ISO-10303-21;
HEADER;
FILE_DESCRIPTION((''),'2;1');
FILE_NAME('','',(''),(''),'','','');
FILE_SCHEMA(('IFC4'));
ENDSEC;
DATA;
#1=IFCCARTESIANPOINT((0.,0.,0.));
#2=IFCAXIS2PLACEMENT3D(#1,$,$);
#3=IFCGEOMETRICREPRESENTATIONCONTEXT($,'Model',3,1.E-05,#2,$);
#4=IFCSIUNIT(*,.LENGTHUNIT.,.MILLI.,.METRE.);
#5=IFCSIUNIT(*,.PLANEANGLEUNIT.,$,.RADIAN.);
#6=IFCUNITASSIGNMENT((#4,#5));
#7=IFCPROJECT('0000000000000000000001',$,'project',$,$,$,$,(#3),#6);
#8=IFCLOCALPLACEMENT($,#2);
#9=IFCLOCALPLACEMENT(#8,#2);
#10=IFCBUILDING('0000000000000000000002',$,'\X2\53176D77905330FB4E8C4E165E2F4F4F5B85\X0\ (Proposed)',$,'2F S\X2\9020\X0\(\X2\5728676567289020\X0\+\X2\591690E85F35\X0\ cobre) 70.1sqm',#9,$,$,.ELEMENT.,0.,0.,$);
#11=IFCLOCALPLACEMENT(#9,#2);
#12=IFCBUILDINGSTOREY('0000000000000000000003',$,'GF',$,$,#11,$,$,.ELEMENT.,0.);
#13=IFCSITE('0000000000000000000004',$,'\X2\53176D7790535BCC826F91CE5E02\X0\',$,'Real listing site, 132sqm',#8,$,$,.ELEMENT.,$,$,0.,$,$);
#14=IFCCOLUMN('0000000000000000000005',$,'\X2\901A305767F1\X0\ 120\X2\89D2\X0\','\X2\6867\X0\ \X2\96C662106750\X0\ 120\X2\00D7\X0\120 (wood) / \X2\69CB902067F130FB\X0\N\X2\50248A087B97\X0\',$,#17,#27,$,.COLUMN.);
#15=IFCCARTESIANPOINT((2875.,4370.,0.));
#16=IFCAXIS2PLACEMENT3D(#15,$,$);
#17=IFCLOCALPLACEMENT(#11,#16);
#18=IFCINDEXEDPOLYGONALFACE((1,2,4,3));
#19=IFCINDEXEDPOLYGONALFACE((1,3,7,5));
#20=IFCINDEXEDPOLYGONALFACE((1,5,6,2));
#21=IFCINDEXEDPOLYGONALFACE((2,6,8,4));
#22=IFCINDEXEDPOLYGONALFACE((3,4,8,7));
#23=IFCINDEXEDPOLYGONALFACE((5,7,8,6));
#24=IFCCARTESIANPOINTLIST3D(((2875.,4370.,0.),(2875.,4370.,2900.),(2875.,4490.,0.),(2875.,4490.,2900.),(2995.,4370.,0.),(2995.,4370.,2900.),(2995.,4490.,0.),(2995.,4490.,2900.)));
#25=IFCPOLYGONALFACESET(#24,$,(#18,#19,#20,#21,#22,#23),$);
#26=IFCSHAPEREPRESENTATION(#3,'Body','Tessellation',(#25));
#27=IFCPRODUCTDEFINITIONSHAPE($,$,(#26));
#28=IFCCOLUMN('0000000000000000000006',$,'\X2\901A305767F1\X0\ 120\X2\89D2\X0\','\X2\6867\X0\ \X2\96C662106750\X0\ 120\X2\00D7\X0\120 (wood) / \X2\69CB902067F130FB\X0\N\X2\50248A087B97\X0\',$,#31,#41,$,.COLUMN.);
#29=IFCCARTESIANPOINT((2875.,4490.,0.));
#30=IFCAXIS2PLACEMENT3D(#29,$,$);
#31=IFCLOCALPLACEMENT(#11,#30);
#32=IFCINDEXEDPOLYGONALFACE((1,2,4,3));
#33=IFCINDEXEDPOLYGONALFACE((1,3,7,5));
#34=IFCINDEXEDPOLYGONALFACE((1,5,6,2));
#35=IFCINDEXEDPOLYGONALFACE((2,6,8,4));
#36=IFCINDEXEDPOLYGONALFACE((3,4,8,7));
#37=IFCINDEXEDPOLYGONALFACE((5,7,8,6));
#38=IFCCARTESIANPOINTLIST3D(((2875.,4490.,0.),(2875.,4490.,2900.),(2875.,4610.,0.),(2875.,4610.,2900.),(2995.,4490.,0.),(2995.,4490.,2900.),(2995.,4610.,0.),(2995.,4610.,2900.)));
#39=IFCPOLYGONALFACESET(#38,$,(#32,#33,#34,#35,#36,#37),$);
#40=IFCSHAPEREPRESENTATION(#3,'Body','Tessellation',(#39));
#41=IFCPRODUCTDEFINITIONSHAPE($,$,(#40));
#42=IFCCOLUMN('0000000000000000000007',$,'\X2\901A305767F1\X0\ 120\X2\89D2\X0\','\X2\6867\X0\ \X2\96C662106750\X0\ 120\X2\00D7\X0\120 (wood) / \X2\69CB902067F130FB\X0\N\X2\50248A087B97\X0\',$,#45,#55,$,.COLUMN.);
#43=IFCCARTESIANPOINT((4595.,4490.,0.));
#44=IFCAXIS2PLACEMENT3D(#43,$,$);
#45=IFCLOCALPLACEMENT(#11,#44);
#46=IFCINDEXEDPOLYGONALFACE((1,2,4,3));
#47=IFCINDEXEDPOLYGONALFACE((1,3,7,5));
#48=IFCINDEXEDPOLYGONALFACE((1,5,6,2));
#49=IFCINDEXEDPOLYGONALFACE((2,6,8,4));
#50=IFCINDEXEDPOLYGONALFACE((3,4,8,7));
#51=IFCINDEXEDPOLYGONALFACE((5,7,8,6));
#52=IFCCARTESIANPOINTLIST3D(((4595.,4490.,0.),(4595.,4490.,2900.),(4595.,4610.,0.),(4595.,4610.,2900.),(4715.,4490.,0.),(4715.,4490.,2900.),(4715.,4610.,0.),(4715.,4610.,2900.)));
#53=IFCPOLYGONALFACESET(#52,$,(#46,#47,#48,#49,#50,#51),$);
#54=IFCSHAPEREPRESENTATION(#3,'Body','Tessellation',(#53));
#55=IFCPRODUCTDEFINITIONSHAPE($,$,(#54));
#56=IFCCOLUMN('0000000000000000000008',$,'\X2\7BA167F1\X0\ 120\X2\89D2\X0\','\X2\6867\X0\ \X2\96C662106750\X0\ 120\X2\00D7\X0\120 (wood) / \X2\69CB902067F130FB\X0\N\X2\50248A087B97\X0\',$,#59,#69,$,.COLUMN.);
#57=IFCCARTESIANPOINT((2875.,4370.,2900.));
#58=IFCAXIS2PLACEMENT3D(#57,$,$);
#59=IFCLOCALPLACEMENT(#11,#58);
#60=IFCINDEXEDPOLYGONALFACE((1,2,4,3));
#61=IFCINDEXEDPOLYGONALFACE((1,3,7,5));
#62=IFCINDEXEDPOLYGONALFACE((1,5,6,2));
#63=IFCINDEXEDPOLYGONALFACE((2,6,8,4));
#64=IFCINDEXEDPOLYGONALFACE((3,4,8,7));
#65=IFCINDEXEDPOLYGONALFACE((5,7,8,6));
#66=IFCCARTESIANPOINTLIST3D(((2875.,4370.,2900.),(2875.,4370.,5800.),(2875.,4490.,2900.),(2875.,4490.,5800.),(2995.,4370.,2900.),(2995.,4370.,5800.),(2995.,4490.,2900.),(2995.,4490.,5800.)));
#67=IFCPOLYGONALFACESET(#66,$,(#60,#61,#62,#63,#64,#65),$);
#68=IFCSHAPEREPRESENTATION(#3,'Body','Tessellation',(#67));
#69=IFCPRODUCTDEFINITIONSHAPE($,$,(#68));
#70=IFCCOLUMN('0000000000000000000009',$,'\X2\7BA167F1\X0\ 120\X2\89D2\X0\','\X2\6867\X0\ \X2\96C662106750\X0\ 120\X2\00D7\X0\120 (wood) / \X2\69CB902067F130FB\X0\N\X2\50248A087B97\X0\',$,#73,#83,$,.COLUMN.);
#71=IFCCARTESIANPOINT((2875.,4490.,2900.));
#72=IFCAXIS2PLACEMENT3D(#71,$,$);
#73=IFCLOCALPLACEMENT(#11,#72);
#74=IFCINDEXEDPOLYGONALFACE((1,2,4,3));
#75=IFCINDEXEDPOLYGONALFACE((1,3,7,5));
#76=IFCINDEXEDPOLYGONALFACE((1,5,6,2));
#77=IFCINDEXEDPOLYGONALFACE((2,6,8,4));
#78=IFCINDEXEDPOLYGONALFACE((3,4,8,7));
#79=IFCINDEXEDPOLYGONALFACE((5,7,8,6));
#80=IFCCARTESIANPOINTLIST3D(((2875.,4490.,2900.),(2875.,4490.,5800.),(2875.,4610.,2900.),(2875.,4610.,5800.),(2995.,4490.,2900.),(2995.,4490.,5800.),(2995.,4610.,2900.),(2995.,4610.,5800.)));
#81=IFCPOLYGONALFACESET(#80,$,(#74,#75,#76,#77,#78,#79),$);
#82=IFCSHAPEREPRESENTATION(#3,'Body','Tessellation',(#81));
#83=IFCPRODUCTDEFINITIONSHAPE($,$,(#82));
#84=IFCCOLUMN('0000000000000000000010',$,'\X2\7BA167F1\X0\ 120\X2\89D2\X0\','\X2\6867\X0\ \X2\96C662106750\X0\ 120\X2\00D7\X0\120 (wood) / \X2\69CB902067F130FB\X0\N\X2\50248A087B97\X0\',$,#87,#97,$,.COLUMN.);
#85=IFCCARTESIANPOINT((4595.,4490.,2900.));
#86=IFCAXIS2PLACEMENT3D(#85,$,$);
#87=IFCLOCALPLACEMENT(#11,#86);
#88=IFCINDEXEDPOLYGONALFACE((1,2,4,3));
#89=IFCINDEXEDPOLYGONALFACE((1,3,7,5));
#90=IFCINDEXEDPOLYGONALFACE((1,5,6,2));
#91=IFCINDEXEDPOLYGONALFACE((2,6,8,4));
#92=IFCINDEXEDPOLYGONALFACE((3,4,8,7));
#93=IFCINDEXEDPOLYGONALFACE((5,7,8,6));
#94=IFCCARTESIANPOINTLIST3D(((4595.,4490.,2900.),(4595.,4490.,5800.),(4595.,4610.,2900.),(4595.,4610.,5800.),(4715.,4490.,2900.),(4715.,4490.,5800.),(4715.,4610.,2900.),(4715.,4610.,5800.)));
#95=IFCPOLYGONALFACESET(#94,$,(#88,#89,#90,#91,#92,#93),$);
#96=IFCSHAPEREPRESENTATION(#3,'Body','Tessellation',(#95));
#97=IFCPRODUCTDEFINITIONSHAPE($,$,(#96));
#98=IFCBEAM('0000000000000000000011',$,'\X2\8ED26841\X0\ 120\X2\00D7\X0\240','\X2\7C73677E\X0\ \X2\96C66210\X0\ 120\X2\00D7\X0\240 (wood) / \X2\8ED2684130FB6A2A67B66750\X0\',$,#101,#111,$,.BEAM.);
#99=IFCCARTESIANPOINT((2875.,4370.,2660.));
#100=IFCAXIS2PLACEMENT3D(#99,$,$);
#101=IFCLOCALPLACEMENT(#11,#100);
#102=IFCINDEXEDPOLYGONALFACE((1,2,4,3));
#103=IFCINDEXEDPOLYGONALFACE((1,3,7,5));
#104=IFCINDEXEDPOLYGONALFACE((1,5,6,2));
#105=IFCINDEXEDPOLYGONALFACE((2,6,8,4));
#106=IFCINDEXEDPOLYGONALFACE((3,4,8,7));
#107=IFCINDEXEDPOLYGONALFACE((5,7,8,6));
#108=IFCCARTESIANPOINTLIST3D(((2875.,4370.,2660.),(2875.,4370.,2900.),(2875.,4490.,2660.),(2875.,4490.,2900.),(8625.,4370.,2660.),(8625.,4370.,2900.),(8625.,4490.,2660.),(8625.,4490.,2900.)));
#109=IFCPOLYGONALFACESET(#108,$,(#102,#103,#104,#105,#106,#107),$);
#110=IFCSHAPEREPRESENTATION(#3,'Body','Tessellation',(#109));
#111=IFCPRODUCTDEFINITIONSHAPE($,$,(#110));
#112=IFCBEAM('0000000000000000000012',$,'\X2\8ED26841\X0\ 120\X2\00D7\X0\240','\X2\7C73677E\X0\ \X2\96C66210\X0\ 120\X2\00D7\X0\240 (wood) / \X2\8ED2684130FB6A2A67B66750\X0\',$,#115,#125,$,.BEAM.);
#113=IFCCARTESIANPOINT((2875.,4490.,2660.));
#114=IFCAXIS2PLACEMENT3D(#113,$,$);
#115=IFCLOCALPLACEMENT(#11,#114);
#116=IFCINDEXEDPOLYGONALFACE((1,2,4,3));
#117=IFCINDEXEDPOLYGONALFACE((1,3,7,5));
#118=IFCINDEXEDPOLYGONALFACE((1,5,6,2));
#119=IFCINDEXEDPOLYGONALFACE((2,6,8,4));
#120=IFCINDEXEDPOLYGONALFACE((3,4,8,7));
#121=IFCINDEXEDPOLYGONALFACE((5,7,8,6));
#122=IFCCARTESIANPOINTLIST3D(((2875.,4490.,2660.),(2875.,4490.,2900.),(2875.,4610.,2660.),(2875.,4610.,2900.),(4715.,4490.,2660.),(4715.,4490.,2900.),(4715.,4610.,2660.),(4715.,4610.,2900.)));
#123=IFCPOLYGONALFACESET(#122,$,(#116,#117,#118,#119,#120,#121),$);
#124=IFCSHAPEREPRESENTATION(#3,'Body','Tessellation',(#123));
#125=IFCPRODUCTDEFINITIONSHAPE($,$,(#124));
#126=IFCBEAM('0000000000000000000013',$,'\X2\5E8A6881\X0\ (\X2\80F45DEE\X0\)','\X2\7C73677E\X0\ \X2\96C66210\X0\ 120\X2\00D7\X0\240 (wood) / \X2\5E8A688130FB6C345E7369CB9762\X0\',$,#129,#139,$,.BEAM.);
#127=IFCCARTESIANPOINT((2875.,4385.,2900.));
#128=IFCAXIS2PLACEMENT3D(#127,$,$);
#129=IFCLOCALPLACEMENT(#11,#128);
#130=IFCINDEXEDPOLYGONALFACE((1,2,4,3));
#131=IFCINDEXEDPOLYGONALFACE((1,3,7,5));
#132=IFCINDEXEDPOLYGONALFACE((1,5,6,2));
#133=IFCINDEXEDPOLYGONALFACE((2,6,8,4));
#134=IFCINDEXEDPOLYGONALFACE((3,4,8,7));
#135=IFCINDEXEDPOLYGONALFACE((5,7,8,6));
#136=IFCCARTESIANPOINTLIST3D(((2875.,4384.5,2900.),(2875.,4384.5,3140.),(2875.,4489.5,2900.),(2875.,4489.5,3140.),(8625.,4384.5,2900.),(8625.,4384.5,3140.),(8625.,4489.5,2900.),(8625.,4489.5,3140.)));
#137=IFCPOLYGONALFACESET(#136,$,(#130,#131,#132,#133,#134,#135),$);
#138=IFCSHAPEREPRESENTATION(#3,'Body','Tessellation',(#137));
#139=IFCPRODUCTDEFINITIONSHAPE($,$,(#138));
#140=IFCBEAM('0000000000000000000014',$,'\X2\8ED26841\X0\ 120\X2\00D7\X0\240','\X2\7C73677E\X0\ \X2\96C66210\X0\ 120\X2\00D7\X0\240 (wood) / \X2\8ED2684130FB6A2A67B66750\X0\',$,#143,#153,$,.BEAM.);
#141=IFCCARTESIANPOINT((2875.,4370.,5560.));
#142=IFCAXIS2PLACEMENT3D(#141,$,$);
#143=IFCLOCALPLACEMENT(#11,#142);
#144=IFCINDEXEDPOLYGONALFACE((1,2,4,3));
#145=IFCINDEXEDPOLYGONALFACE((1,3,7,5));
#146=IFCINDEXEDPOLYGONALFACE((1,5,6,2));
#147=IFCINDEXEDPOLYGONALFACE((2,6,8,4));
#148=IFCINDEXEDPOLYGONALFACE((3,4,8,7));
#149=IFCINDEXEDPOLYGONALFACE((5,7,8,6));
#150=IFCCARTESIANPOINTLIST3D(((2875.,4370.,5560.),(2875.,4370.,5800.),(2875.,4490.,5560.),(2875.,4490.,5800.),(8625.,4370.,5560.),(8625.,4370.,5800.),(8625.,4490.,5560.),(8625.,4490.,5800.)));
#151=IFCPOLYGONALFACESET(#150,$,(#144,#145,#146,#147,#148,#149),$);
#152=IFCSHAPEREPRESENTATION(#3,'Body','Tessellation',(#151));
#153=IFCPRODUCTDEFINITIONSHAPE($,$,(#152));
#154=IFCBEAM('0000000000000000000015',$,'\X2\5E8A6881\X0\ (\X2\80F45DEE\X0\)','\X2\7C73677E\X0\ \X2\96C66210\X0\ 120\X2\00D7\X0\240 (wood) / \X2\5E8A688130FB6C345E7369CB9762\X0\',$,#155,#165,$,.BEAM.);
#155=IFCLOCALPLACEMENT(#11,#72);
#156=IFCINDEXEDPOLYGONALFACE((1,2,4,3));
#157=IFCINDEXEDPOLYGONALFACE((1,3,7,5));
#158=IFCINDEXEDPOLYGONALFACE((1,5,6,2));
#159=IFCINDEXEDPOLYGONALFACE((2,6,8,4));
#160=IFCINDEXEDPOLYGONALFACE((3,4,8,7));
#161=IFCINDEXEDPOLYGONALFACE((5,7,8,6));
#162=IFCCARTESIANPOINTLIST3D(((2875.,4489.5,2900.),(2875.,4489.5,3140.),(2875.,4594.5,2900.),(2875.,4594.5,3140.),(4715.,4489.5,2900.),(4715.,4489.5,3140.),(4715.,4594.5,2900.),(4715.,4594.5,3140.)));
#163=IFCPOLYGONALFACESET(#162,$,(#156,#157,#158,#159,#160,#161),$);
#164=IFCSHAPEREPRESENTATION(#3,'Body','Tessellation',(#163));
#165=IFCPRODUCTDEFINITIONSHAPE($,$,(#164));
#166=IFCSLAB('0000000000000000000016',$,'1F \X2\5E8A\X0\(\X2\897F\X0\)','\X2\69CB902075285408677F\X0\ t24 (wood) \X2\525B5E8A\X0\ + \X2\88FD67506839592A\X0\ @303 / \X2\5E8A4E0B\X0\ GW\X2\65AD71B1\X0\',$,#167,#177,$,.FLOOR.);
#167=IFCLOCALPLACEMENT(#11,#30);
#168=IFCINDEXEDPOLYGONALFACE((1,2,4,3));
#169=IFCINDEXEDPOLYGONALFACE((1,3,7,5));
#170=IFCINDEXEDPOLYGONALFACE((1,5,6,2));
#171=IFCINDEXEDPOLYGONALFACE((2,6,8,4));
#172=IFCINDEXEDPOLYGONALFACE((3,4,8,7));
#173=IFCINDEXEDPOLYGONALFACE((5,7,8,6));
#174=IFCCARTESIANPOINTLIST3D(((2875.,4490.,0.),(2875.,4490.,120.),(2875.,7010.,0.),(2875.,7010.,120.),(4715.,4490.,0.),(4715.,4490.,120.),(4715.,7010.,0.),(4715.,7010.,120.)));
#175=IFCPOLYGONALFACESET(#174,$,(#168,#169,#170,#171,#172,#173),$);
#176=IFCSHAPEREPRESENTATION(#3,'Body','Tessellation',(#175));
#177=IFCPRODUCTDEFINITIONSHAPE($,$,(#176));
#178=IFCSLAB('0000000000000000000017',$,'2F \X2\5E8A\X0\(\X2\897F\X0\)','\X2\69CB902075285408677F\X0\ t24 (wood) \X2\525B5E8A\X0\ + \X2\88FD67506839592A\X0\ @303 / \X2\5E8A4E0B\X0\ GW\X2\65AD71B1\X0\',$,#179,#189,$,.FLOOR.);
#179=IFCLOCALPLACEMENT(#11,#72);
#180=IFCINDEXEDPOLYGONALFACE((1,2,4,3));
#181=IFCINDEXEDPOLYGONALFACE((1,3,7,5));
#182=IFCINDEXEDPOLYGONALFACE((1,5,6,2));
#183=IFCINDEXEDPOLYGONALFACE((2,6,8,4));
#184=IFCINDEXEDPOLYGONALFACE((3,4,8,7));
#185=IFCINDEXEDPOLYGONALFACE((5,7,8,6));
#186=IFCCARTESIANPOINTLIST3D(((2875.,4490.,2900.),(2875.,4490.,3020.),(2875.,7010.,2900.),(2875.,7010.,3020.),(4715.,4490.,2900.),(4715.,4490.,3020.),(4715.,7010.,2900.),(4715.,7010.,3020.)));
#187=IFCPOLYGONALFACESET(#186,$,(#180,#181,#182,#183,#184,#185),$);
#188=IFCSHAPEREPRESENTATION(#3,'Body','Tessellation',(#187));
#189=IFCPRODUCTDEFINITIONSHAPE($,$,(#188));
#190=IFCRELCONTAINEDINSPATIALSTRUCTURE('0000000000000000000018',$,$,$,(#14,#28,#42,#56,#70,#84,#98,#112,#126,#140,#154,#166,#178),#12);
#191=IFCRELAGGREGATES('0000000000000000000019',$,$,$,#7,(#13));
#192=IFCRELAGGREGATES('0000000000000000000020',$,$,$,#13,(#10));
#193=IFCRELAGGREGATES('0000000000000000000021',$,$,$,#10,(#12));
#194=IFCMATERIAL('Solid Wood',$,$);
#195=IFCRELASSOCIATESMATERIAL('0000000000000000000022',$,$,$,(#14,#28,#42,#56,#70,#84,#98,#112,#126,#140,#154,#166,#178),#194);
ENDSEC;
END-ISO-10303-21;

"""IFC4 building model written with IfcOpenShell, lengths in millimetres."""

from ifc_helpers import new_model, si_unit, frame, frame_2d, origin, place, context, project, spatial, rectangle, extrude, material, element, save


model = new_model("IFC4")

# Units and contexts
model_context = context("Model", 3, precision=1e-05, world=origin())
ifc_project = project(units=[si_unit("LENGTHUNIT", "METRE", prefix="MILLI"), si_unit("PLANEANGLEUNIT", "RADIAN")], contexts=[model_context])

# Site, building, storey
site_placement = place(None, origin())
site = spatial("IfcSite", under=ifc_project, at=site_placement, Name="北海道富良野市", ObjectType="Real listing site, 132sqm", CompositionType="ELEMENT", RefElevation=0.0)
building_placement = place(site_placement, origin())
building = spatial("IfcBuilding", under=site, at=building_placement, Name="北海道・二世帯住宅 (Proposed)", ObjectType="2F S造(在来木造+外部張 cobre) 70.1sqm", CompositionType="ELEMENT", ElevationOfRefHeight=0.0, ElevationOfTerrain=0.0)
storey_placement = place(building_placement, origin())
storey = spatial("IfcBuildingStorey", under=building, at=storey_placement, Name="GF", CompositionType="ELEMENT", Elevation=0.0)

# Columns
ifc_material_1 = material(Name="Solid Wood")
column_1_placement = place(storey_placement, frame((2875.0, 4370.0, 0.0)))
element("IfcColumn", 1, at=column_1_placement, inside=storey, material=ifc_material_1, Name="通し柱 120角", Description="桧 集成材 120×120 (wood) / 構造柱・N値計算", PredefinedType="COLUMN", context=model_context, shape_type="SweptSolid", body=[
    extrude(rectangle(XDim=120.0, YDim=120.0, at=frame_2d((60.0, 60.0))), frame((2875.0, 4370.0, 0.0)), (0.0, 0.0, 1.0), 2900.0),
])
column_2_placement = place(storey_placement, frame((2875.0, 4490.0, 0.0)))
element("IfcColumn", 2, at=column_2_placement, inside=storey, material=ifc_material_1, Name="通し柱 120角", Description="桧 集成材 120×120 (wood) / 構造柱・N値計算", PredefinedType="COLUMN", context=model_context, shape_type="SweptSolid", body=[
    extrude(rectangle(XDim=120.0, YDim=120.0, at=frame_2d((60.0, 60.0))), frame((2875.0, 4490.0, 0.0)), (0.0, 0.0, 1.0), 2900.0),
])
column_3_placement = place(storey_placement, frame((4595.0, 4490.0, 0.0)))
element("IfcColumn", 3, at=column_3_placement, inside=storey, material=ifc_material_1, Name="通し柱 120角", Description="桧 集成材 120×120 (wood) / 構造柱・N値計算", PredefinedType="COLUMN", context=model_context, shape_type="SweptSolid", body=[
    extrude(rectangle(XDim=120.0, YDim=120.0, at=frame_2d((60.0, 60.0))), frame((4595.0, 4490.0, 0.0)), (0.0, 0.0, 1.0), 2900.0),
])
column_4_placement = place(storey_placement, frame((2875.0, 4370.0, 2900.0)))
element("IfcColumn", 4, at=column_4_placement, inside=storey, material=ifc_material_1, Name="管柱 120角", Description="桧 集成材 120×120 (wood) / 構造柱・N値計算", PredefinedType="COLUMN", context=model_context, shape_type="SweptSolid", body=[
    extrude(rectangle(XDim=120.0, YDim=120.0, at=frame_2d((60.0, 60.0))), frame((2875.0, 4370.0, 2900.0)), (0.0, 0.0, 1.0), 2900.0),
])
column_5_placement = place(storey_placement, frame((2875.0, 4490.0, 2900.0)))
element("IfcColumn", 5, at=column_5_placement, inside=storey, material=ifc_material_1, Name="管柱 120角", Description="桧 集成材 120×120 (wood) / 構造柱・N値計算", PredefinedType="COLUMN", context=model_context, shape_type="SweptSolid", body=[
    extrude(rectangle(XDim=120.0, YDim=120.0, at=frame_2d((60.0, 60.0))), frame((2875.0, 4490.0, 2900.0)), (0.0, 0.0, 1.0), 2900.0),
])
column_6_placement = place(storey_placement, frame((4595.0, 4490.0, 2900.0)))
element("IfcColumn", 6, at=column_6_placement, inside=storey, material=ifc_material_1, Name="管柱 120角", Description="桧 集成材 120×120 (wood) / 構造柱・N値計算", PredefinedType="COLUMN", context=model_context, shape_type="SweptSolid", body=[
    extrude(rectangle(XDim=120.0, YDim=120.0, at=frame_2d((60.0, 60.0))), frame((4595.0, 4490.0, 2900.0)), (0.0, 0.0, 1.0), 2900.0),
])

# Beams
beam_1_placement = place(storey_placement, frame((2875.0, 4370.0, 2660.0)))
element("IfcBeam", 7, at=beam_1_placement, inside=storey, material=ifc_material_1, Name="軒桁 120×240", Description="米松 集成 120×240 (wood) / 軒桁・横架材", PredefinedType="BEAM", context=model_context, shape_type="SweptSolid", body=[
    extrude(rectangle(XDim=5750.0, YDim=120.0, at=frame_2d((2875.0, 60.0))), frame((2875.0, 4370.0, 2660.0)), (0.0, 0.0, 1.0), 240.0),
])
beam_2_placement = place(storey_placement, frame((2875.0, 4490.0, 2660.0)))
element("IfcBeam", 8, at=beam_2_placement, inside=storey, material=ifc_material_1, Name="軒桁 120×240", Description="米松 集成 120×240 (wood) / 軒桁・横架材", PredefinedType="BEAM", context=model_context, shape_type="SweptSolid", body=[
    extrude(rectangle(XDim=1840.0, YDim=120.0, at=frame_2d((920.0, 60.0))), frame((2875.0, 4490.0, 2660.0)), (0.0, 0.0, 1.0), 240.0),
])
beam_3_placement = place(storey_placement, frame((2875.0, 4385.0, 2900.0)))
element("IfcBeam", 9, at=beam_3_placement, inside=storey, material=ifc_material_1, Name="床梁 (胴差)", Description="米松 集成 120×240 (wood) / 床梁・水平構面", PredefinedType="BEAM", context=model_context, shape_type="SweptSolid", body=[
    extrude(rectangle(XDim=5750.0, YDim=105.0, at=frame_2d((2875.0, 52.0))), frame((2875.0, 4385.0, 2900.0)), (0.0, 0.0, 1.0), 240.0),
])
beam_4_placement = place(storey_placement, frame((2875.0, 4370.0, 5560.0)))
element("IfcBeam", 10, at=beam_4_placement, inside=storey, material=ifc_material_1, Name="軒桁 120×240", Description="米松 集成 120×240 (wood) / 軒桁・横架材", PredefinedType="BEAM", context=model_context, shape_type="SweptSolid", body=[
    extrude(rectangle(XDim=5750.0, YDim=120.0, at=frame_2d((2875.0, 60.0))), frame((2875.0, 4370.0, 5560.0)), (0.0, 0.0, 1.0), 240.0),
])
beam_5_placement = place(storey_placement, frame((2875.0, 4490.0, 2900.0)))
element("IfcBeam", 11, at=beam_5_placement, inside=storey, material=ifc_material_1, Name="床梁 (胴差)", Description="米松 集成 120×240 (wood) / 床梁・水平構面", PredefinedType="BEAM", context=model_context, shape_type="SweptSolid", body=[
    extrude(rectangle(XDim=1840.0, YDim=105.0, at=frame_2d((920.0, 52.0))), frame((2875.0, 4490.0, 2900.0)), (0.0, 0.0, 1.0), 240.0),
])

# Slabs
slab_1_placement = place(storey_placement, frame((2875.0, 4490.0, 0.0)))
element("IfcSlab", 12, at=slab_1_placement, inside=storey, material=ifc_material_1, Name="1F 床(西)", Description="構造用合板 t24 (wood) 剛床 + 製材根太 @303 / 床下 GW断熱", PredefinedType="FLOOR", context=model_context, shape_type="SweptSolid", body=[
    extrude(rectangle(XDim=1840.0, YDim=2520.0, at=frame_2d((920.0, 1260.0))), frame((2875.0, 4490.0, 0.0)), (0.0, 0.0, 1.0), 120.0),
])
slab_2_placement = place(storey_placement, frame((2875.0, 4490.0, 2900.0)))
element("IfcSlab", 13, at=slab_2_placement, inside=storey, material=ifc_material_1, Name="2F 床(西)", Description="構造用合板 t24 (wood) 剛床 + 製材根太 @303 / 床下 GW断熱", PredefinedType="FLOOR", context=model_context, shape_type="SweptSolid", body=[
    extrude(rectangle(XDim=1840.0, YDim=2520.0, at=frame_2d((920.0, 1260.0))), frame((2875.0, 4490.0, 2900.0)), (0.0, 0.0, 1.0), 120.0),
])

save(model, "model.ifc")
